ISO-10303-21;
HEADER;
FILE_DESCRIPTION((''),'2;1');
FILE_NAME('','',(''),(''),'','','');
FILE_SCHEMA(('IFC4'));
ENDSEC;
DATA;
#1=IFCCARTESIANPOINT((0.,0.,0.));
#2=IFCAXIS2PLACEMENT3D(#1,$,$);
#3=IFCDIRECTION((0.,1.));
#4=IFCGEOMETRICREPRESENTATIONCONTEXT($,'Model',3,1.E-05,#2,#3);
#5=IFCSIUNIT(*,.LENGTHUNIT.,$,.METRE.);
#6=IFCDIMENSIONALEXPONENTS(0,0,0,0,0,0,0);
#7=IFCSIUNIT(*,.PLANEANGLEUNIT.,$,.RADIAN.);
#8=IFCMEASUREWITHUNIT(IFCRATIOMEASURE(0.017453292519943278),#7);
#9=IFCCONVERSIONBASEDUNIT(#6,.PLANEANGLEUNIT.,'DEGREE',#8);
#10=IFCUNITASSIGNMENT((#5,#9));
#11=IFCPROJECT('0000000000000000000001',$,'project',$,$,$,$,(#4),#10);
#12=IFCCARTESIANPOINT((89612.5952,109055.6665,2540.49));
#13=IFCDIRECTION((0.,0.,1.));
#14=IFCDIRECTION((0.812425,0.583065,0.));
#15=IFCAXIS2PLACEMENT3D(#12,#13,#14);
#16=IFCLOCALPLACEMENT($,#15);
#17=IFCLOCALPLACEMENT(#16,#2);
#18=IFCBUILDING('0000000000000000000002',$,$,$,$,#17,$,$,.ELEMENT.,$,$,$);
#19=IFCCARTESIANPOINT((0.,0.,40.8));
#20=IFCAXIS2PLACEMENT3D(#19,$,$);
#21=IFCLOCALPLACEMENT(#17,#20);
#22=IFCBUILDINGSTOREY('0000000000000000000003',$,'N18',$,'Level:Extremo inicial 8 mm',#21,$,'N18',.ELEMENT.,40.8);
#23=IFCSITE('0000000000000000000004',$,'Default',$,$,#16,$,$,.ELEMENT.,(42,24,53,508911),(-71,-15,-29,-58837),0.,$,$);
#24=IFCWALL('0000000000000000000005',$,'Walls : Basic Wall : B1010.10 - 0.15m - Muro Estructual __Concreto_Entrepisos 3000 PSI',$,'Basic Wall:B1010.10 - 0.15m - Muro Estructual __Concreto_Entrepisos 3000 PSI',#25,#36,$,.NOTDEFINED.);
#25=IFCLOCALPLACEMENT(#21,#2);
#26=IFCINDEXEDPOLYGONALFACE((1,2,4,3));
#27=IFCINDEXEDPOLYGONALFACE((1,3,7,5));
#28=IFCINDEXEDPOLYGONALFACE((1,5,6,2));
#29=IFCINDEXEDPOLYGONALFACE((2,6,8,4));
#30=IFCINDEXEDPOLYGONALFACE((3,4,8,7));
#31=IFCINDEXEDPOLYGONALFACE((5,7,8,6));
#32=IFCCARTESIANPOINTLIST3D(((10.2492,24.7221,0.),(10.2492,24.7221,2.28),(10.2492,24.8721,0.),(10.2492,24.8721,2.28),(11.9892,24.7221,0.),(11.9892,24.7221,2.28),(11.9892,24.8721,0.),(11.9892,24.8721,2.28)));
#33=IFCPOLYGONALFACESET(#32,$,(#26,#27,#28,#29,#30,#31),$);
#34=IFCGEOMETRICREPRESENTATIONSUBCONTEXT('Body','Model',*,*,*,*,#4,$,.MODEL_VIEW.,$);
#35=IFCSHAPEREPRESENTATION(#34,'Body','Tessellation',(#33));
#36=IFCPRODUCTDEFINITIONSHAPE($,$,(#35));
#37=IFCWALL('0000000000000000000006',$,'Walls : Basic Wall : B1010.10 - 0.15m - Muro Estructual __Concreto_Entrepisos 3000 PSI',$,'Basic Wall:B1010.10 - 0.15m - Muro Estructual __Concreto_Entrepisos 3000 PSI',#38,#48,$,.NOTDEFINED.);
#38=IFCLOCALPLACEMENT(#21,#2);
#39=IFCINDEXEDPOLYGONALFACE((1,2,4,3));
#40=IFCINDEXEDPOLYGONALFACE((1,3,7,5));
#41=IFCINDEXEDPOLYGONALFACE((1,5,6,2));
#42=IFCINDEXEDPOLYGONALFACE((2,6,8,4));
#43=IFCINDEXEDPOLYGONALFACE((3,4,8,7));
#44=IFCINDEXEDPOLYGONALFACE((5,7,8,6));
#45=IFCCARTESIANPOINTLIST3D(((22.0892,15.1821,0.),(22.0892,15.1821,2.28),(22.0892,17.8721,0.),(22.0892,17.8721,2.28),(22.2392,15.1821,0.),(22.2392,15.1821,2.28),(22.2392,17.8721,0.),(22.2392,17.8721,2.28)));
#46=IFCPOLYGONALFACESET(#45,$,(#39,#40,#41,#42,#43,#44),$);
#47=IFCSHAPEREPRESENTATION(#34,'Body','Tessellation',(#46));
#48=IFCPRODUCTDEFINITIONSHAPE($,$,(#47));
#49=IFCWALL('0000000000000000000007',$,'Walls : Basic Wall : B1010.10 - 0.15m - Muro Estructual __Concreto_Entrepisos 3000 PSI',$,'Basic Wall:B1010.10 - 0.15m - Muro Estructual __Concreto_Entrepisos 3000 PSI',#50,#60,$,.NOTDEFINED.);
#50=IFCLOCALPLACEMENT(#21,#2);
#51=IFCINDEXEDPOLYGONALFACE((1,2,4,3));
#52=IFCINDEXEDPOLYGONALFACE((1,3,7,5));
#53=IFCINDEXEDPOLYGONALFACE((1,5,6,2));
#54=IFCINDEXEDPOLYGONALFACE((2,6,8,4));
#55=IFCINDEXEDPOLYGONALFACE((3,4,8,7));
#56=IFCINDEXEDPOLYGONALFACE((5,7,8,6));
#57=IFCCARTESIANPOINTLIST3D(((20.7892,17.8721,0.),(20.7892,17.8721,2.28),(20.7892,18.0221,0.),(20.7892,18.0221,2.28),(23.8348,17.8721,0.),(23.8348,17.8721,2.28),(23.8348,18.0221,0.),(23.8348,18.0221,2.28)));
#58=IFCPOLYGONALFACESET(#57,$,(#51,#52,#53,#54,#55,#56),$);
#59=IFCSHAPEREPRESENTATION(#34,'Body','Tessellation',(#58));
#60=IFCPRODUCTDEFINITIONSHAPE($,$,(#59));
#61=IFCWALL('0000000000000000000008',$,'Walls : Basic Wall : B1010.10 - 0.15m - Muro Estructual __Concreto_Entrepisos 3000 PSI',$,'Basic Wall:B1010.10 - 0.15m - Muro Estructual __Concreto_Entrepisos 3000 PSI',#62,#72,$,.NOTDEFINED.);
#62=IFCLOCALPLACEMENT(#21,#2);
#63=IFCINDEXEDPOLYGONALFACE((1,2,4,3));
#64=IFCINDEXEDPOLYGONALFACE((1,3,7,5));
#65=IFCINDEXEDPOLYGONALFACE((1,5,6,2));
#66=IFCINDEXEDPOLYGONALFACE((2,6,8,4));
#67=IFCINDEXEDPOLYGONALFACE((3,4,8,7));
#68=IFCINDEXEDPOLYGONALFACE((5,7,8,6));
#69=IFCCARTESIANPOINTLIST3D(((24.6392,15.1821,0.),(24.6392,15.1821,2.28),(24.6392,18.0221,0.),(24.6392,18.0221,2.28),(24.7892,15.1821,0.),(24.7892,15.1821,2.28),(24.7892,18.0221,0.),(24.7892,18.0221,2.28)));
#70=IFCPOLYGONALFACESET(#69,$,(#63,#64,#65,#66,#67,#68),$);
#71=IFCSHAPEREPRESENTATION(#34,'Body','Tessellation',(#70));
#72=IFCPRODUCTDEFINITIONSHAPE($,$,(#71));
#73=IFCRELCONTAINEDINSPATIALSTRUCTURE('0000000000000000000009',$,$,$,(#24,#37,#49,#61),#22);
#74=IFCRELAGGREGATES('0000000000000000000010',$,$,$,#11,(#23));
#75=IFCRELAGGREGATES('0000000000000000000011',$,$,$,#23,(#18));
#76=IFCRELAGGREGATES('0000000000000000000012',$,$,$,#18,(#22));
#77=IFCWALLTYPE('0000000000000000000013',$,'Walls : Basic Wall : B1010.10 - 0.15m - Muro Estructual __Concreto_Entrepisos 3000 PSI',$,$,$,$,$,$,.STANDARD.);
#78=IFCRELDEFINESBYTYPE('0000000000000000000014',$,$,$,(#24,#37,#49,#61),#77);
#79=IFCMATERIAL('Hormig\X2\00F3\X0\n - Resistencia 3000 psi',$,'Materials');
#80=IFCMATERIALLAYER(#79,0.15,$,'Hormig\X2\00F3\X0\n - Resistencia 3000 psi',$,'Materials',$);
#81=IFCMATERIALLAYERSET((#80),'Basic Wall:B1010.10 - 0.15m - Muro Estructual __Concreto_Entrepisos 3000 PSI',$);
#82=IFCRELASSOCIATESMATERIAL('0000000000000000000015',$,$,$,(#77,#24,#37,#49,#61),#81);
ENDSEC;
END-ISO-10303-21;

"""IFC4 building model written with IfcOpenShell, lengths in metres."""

from ifc_helpers import new_model, entity, si_unit, converted_unit, direction, frame, frame_2d, origin, place, context, subcontext, project, spatial, rectangle, extrude, material, layer, layer_set, layer_usage, type_object, element, save


model = new_model("IFC4")

# Units and contexts
model_context = context("Model", 3, precision=1e-05, world=origin(), true_north=direction((0.0, 1.0)))
body_context = subcontext(model_context, "Body", "Model", "MODEL_VIEW")
ifc_project = project(units=[si_unit("LENGTHUNIT", "METRE"), converted_unit("PLANEANGLEUNIT", "DEGREE", entity("IfcRatioMeasure", 0.017453292519943278), si_unit("PLANEANGLEUNIT", "RADIAN"), dimensions=[0, 0, 0, 0, 0, 0, 0])], contexts=[model_context])

# Site, building, storey
site_placement = place(None, frame((89612.5952, 109055.6665, 2540.49), z_axis=(0.0, 0.0, 1.0), x_axis=(0.812425, 0.583065, 0.0)))
site = spatial("IfcSite", under=ifc_project, at=site_placement, Name="Default", CompositionType="ELEMENT", RefLatitude=(42, 24, 53, 508911), RefLongitude=(-71, -15, -29, -58837), RefElevation=0.0)
building_placement = place(site_placement, origin())
building = spatial("IfcBuilding", under=site, at=building_placement, CompositionType="ELEMENT")
storey_placement = place(building_placement, frame((0.0, 0.0, 40.8)))
storey = spatial("IfcBuildingStorey", under=building, at=storey_placement, Name="N18", ObjectType="Level:Extremo inicial 8 mm", LongName="N18", CompositionType="ELEMENT", Elevation=40.8)

# Walls
ifc_material = material(Name="Hormigón - Resistencia 3000 psi", Category="Materials")
ifc_layer_1 = layer(ifc_material, 0.15, Name="Hormigón - Resistencia 3000 psi", Category="Materials")
ifc_layer_set_1 = layer_set([ifc_layer_1], Name="Basic Wall:B1010.10 - 0.15m - Muro Estructual __Concreto_Entrepisos 3000 PSI")
wall_type_1 = type_object("IfcWallType", Name="Walls : Basic Wall : B1010.10 - 0.15m - Muro Estructual __Concreto_Entrepisos 3000 PSI", PredefinedType="STANDARD", material=ifc_layer_set_1)
ifc_layer_usage_1 = layer_usage(ifc_layer_set_1, "AXIS2", "POSITIVE", -0.075)
wall_1_placement = place(storey_placement, frame((11.9892, 24.7971, 0.0), z_axis=(0.0, 0.0, 1.0), x_axis=(-1.0, 0.0, 0.0)))
element("IfcWall", 1, at=wall_1_placement, inside=storey, type_object=wall_type_1, material=ifc_layer_usage_1, Name="Walls : Basic Wall : B1010.10 - 0.15m - Muro Estructual __Concreto_Entrepisos 3000 PSI", ObjectType="Basic Wall:B1010.10 - 0.15m - Muro Estructual __Concreto_Entrepisos 3000 PSI", PredefinedType="NOTDEFINED", context=body_context, shape_type="SweptSolid", body=[
    extrude(rectangle(XDim=1.74, YDim=0.15, at=frame_2d((0.87, 0.0), x_axis=(-1.0, 0.0))), origin(), (0.0, 0.0, 1.0), 2.28),
])
ifc_layer_usage_2 = layer_usage(ifc_layer_set_1, "AXIS2", "POSITIVE", -0.075)
wall_2_placement = place(storey_placement, frame((22.1642, 15.1821, 0.0), z_axis=(0.0, 0.0, 1.0), x_axis=(0.0, 1.0, 0.0)))
element("IfcWall", 2, at=wall_2_placement, inside=storey, type_object=wall_type_1, material=ifc_layer_usage_2, Name="Walls : Basic Wall : B1010.10 - 0.15m - Muro Estructual __Concreto_Entrepisos 3000 PSI", ObjectType="Basic Wall:B1010.10 - 0.15m - Muro Estructual __Concreto_Entrepisos 3000 PSI", PredefinedType="NOTDEFINED", context=body_context, shape_type="SweptSolid", body=[
    extrude(rectangle(XDim=2.69, YDim=0.15, at=frame_2d((1.345, 0.0), x_axis=(-1.0, 0.0))), origin(), (0.0, 0.0, 1.0), 2.28),
])
ifc_layer_usage_3 = layer_usage(ifc_layer_set_1, "AXIS2", "POSITIVE", -0.075)
wall_3_placement = place(storey_placement, frame((20.7892, 17.9471, 0.0)))
element("IfcWall", 3, at=wall_3_placement, inside=storey, type_object=wall_type_1, material=ifc_layer_usage_3, Name="Walls : Basic Wall : B1010.10 - 0.15m - Muro Estructual __Concreto_Entrepisos 3000 PSI", ObjectType="Basic Wall:B1010.10 - 0.15m - Muro Estructual __Concreto_Entrepisos 3000 PSI", PredefinedType="NOTDEFINED", context=body_context, shape_type="SweptSolid", body=[
    extrude(rectangle(XDim=3.0455, YDim=0.15, at=frame_2d((1.5228, 0.0), x_axis=(-1.0, 0.0))), origin(), (0.0, 0.0, 1.0), 2.28),
])
ifc_layer_usage_4 = layer_usage(ifc_layer_set_1, "AXIS2", "POSITIVE", -0.075)
wall_4_placement = place(storey_placement, frame((24.7142, 15.1821, 0.0), z_axis=(0.0, 0.0, 1.0), x_axis=(0.0, 1.0, 0.0)))
element("IfcWall", 4, at=wall_4_placement, inside=storey, type_object=wall_type_1, material=ifc_layer_usage_4, Name="Walls : Basic Wall : B1010.10 - 0.15m - Muro Estructual __Concreto_Entrepisos 3000 PSI", ObjectType="Basic Wall:B1010.10 - 0.15m - Muro Estructual __Concreto_Entrepisos 3000 PSI", PredefinedType="NOTDEFINED", context=body_context, shape_type="SweptSolid", body=[
    extrude(rectangle(XDim=2.84, YDim=0.15, at=frame_2d((1.42, 0.0), x_axis=(-1.0, 0.0))), origin(), (0.0, 0.0, 1.0), 2.28),
])

save(model, "model.ifc")
